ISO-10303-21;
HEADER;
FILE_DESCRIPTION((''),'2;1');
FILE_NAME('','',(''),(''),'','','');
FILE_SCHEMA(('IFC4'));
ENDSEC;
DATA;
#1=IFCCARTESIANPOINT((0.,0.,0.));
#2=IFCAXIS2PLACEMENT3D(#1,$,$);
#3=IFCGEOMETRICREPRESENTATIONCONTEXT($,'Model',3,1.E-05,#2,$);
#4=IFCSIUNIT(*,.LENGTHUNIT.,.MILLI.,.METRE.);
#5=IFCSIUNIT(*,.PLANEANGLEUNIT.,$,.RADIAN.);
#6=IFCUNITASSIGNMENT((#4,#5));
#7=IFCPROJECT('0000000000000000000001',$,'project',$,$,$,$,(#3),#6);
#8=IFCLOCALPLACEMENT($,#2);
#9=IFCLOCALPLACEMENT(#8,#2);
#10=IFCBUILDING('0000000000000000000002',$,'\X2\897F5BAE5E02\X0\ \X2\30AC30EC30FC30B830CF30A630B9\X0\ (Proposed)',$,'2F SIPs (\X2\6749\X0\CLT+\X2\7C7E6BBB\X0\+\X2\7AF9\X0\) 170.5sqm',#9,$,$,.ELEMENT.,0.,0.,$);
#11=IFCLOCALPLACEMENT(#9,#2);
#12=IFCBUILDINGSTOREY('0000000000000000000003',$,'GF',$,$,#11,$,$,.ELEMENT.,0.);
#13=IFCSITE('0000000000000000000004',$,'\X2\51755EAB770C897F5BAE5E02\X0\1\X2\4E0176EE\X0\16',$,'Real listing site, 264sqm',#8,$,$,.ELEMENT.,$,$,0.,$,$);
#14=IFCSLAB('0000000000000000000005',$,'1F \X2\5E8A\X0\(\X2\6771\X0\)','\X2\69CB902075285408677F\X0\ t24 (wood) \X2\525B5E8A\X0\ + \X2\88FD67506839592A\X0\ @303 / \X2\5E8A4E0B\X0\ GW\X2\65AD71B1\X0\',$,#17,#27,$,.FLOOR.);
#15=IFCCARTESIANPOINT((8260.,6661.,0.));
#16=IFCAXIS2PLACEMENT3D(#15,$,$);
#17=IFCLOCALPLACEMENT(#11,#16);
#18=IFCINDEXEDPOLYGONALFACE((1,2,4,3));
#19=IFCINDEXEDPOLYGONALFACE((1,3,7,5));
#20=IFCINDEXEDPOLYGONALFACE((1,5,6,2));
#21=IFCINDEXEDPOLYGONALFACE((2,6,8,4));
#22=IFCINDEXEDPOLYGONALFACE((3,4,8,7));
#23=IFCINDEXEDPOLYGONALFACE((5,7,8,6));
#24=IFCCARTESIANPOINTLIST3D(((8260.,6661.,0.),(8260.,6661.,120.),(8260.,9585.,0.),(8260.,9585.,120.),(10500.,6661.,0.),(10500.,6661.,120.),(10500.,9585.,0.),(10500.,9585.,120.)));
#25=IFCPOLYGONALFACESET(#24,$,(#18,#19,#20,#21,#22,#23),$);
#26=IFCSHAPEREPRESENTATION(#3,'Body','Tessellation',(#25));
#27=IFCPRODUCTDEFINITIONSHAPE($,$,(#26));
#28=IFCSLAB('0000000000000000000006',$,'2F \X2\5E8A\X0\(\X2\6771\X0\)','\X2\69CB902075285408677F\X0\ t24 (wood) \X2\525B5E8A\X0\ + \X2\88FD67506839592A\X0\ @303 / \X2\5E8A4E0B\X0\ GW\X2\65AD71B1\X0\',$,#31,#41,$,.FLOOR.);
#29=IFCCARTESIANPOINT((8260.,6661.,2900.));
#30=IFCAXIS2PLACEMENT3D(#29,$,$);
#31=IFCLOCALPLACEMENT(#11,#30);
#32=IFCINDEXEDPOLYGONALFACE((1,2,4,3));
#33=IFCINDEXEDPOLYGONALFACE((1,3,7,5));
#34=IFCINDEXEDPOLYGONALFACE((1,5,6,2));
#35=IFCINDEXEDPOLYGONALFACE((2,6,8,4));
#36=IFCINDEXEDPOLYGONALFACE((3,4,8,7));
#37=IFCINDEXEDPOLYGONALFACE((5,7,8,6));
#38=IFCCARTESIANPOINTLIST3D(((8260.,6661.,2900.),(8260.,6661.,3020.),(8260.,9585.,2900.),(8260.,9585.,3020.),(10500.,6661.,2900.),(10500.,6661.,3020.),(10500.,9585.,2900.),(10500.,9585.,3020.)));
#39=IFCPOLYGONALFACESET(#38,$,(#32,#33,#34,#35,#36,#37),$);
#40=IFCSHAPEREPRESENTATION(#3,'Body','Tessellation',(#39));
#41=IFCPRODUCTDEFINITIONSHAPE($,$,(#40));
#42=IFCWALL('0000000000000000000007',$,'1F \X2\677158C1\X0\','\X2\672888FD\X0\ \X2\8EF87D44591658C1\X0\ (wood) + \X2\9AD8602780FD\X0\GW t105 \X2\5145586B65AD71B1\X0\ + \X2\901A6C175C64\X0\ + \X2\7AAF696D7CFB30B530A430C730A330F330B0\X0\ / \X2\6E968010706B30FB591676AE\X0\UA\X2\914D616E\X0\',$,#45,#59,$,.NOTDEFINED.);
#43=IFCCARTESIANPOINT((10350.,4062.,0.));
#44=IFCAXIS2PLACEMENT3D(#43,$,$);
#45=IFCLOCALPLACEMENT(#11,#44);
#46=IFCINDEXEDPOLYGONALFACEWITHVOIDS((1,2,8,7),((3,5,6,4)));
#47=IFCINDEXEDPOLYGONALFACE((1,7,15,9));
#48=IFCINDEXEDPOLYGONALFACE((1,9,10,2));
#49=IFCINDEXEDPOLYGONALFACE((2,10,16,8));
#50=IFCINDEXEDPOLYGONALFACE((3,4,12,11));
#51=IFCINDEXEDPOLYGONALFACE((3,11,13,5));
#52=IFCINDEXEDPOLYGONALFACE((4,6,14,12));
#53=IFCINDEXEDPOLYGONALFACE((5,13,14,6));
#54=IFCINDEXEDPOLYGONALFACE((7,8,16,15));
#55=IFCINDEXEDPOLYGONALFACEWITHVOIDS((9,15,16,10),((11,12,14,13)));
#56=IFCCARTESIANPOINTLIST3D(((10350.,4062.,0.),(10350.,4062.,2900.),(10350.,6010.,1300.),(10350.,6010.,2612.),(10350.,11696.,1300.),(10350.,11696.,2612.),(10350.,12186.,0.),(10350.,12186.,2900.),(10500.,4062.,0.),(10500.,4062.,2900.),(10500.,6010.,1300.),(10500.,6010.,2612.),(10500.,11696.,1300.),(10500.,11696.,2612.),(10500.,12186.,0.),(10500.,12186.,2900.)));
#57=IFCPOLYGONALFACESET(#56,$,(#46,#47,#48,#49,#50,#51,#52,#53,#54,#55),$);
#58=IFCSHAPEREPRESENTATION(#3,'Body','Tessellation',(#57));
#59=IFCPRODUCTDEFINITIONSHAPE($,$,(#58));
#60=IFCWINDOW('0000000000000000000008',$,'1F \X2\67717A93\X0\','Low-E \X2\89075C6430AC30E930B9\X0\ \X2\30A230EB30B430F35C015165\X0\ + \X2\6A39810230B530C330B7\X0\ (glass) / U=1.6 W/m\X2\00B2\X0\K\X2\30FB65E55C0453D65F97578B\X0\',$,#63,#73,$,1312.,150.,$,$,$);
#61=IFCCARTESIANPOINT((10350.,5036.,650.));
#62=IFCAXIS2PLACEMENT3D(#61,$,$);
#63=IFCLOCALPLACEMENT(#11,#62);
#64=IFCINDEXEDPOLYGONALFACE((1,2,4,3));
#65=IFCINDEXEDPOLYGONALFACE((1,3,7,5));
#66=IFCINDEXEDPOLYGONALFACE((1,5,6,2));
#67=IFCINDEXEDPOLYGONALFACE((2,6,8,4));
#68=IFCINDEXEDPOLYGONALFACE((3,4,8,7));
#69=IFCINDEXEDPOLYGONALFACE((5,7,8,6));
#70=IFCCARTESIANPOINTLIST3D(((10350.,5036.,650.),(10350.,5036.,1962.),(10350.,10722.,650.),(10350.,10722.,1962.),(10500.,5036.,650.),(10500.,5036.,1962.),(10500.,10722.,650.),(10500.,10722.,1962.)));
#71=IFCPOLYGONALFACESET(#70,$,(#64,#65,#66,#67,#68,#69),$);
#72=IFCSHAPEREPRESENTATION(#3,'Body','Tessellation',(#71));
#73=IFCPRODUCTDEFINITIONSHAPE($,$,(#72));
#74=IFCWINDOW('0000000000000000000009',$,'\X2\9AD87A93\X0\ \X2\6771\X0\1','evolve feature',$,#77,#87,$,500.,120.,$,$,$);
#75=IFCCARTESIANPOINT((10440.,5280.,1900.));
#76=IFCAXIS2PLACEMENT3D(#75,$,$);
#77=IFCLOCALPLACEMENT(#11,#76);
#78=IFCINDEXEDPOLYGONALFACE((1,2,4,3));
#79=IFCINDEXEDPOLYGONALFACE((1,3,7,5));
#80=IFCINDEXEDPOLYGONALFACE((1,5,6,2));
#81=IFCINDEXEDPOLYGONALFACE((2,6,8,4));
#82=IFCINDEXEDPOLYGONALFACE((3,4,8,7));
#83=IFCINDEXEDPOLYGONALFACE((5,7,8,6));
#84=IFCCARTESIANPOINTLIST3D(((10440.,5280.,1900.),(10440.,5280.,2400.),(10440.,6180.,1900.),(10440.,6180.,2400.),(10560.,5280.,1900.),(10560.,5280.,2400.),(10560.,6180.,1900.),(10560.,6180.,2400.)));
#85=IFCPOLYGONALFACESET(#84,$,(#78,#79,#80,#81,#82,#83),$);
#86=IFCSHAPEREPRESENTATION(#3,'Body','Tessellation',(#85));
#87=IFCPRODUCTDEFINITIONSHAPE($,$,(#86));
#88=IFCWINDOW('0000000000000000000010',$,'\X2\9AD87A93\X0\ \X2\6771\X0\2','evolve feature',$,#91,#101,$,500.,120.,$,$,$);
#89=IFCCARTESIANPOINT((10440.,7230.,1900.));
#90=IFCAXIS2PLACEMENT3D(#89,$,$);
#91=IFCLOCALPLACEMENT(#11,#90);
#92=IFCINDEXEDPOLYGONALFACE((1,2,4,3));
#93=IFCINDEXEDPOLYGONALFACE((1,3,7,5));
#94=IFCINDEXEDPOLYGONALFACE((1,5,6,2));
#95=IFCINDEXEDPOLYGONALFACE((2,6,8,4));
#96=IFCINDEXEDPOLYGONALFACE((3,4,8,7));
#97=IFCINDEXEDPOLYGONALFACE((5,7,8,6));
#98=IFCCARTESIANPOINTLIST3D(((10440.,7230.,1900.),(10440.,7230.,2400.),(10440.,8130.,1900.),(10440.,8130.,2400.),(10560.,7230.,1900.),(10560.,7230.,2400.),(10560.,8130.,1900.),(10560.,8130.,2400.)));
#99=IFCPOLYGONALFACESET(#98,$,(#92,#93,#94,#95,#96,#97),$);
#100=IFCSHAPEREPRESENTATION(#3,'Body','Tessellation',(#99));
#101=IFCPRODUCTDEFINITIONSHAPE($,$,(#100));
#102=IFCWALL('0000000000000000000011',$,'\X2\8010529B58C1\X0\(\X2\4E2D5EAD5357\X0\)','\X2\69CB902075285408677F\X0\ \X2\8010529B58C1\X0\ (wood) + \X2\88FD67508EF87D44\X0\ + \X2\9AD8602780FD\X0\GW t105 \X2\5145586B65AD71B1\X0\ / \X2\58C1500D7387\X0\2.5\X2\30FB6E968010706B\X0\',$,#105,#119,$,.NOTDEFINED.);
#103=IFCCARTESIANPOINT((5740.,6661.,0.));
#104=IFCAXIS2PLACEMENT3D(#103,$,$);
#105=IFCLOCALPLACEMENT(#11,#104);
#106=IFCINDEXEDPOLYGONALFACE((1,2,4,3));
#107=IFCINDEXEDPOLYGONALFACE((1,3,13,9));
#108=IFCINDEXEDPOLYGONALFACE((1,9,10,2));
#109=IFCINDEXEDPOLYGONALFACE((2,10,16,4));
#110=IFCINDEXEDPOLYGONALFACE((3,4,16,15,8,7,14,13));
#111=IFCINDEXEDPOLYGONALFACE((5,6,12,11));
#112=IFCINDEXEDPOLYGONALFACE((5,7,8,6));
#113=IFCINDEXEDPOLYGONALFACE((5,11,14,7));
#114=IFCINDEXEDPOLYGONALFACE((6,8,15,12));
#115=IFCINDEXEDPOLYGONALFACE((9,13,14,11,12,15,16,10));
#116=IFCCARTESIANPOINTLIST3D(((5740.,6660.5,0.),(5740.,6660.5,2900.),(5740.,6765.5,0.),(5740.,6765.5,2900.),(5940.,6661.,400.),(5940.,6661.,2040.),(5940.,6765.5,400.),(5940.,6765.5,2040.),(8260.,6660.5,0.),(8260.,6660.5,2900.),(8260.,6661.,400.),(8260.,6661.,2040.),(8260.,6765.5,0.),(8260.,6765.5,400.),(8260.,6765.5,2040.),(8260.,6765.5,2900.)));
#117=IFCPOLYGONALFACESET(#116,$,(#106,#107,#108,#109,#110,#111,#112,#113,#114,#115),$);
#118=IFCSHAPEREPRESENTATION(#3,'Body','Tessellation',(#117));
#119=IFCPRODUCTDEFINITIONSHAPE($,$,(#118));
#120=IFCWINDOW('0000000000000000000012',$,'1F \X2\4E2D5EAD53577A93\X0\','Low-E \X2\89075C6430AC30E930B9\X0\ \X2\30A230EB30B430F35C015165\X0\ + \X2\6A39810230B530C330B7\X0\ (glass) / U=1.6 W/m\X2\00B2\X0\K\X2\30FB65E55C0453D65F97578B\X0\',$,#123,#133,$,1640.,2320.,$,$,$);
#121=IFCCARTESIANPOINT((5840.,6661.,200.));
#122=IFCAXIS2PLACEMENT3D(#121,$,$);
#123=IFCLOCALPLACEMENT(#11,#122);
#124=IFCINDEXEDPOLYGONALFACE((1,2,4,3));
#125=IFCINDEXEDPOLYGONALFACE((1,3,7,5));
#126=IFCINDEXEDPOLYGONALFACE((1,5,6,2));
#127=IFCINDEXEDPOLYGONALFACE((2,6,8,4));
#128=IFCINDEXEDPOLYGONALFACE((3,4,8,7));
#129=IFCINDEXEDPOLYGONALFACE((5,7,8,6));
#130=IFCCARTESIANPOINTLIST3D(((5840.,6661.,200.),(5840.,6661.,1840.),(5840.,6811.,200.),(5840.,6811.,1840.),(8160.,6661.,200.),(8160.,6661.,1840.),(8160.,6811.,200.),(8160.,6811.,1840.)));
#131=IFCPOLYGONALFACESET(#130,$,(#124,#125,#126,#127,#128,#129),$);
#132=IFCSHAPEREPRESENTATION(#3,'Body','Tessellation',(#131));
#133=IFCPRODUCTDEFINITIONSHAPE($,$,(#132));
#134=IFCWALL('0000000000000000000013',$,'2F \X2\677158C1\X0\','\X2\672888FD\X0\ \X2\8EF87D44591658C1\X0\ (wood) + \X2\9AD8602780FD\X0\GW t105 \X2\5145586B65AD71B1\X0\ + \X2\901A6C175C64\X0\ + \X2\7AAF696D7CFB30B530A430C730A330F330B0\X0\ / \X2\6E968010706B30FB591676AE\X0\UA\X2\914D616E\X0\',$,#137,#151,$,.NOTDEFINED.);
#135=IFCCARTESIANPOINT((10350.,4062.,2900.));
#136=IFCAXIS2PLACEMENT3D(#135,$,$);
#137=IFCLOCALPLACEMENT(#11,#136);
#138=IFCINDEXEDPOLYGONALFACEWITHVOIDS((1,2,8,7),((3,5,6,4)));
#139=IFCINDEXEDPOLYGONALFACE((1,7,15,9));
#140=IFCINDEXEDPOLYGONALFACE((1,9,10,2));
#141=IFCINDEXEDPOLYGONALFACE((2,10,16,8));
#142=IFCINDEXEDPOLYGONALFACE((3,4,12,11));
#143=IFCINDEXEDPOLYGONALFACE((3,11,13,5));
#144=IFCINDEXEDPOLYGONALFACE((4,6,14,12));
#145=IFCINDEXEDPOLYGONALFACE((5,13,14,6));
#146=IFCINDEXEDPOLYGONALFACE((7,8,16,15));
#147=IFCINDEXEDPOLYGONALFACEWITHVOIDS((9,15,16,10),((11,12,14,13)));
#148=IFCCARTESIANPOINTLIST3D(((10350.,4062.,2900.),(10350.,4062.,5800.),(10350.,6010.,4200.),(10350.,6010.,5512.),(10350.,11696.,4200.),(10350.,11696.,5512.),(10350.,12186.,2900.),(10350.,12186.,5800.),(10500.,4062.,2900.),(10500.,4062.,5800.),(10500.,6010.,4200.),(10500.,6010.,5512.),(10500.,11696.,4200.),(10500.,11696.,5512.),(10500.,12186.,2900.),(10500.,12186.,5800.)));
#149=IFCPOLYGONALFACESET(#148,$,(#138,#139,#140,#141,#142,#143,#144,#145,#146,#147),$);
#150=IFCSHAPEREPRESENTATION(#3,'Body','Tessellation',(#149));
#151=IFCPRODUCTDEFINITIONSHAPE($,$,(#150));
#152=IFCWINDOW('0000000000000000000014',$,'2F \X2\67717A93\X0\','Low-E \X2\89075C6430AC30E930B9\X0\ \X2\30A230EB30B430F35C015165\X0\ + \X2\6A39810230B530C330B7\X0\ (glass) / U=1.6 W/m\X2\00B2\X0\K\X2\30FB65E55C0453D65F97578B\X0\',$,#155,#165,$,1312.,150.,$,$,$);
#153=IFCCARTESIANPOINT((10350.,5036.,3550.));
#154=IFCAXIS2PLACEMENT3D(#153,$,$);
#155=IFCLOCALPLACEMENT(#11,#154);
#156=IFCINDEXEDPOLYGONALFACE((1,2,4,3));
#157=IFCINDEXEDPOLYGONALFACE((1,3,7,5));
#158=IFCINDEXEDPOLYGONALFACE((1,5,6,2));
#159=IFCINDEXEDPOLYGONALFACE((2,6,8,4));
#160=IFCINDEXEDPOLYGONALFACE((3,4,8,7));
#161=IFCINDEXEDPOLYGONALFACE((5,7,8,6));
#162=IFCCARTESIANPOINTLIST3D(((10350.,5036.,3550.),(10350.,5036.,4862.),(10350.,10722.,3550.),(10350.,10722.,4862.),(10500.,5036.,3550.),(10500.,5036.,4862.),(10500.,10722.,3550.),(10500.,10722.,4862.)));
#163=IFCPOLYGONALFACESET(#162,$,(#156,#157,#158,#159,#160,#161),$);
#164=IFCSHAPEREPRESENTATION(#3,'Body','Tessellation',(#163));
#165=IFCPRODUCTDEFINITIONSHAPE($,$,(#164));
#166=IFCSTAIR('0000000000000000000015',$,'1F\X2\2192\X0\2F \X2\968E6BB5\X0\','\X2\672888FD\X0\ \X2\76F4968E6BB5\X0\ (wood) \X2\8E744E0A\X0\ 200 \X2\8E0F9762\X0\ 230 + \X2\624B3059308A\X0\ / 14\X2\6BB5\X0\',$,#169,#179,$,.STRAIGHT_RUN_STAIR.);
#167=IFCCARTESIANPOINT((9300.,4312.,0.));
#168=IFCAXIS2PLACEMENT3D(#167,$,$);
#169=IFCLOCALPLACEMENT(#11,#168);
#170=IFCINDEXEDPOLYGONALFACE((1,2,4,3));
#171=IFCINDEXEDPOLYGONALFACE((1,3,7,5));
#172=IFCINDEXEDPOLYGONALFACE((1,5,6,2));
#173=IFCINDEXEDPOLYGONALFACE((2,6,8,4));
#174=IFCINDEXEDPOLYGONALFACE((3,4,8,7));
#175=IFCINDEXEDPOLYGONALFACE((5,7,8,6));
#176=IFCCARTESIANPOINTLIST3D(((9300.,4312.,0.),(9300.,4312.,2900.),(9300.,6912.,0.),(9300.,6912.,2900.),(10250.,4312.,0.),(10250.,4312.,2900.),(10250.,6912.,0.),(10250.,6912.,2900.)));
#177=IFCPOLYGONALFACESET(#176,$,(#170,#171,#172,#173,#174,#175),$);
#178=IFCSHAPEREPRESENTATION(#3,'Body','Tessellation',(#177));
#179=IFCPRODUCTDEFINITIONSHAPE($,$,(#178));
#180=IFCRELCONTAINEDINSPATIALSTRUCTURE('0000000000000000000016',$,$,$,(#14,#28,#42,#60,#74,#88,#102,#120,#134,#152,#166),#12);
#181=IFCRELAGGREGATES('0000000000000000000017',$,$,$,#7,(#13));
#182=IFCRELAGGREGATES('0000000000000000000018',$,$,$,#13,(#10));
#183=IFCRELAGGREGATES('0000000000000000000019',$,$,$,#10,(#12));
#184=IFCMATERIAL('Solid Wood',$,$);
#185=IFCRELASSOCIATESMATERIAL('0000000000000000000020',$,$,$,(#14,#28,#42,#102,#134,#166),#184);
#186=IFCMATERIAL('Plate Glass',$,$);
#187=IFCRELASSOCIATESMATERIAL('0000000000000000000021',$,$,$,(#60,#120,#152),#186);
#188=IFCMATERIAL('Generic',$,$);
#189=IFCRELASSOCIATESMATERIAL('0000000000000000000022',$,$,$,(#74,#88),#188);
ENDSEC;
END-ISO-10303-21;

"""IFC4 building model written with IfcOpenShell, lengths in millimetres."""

from ifc_helpers import new_model, si_unit, frame, frame_2d, origin, place, context, project, spatial, rectangle, extrude, material, element, fill, save


model = new_model("IFC4")

# Units and contexts
model_context = context("Model", 3, precision=1e-05, world=origin())
ifc_project = project(units=[si_unit("LENGTHUNIT", "METRE", prefix="MILLI"), si_unit("PLANEANGLEUNIT", "RADIAN")], contexts=[model_context])

# Site, building, storey
site_placement = place(None, origin())
site = spatial("IfcSite", under=ifc_project, at=site_placement, Name="兵庫県西宮市1丁目16", ObjectType="Real listing site, 264sqm", CompositionType="ELEMENT", RefElevation=0.0)
building_placement = place(site_placement, origin())
building = spatial("IfcBuilding", under=site, at=building_placement, Name="西宮市 ガレージハウス (Proposed)", ObjectType="2F SIPs (杉CLT+籾殻+竹) 170.5sqm", CompositionType="ELEMENT", ElevationOfRefHeight=0.0, ElevationOfTerrain=0.0)
storey_placement = place(building_placement, origin())
storey = spatial("IfcBuildingStorey", under=building, at=storey_placement, Name="GF", CompositionType="ELEMENT", Elevation=0.0)

# Slabs
ifc_material_1 = material(Name="Solid Wood")
slab_1_placement = place(storey_placement, frame((8260.0, 6661.0, 0.0)))
element("IfcSlab", 1, at=slab_1_placement, inside=storey, material=ifc_material_1, Name="1F 床(東)", Description="構造用合板 t24 (wood) 剛床 + 製材根太 @303 / 床下 GW断熱", PredefinedType="FLOOR", context=model_context, shape_type="SweptSolid", body=[
    extrude(rectangle(XDim=2240.0, YDim=2924.0, at=frame_2d((1120.0, 1462.0))), frame((8260.0, 6661.0, 0.0)), (0.0, 0.0, 1.0), 120.0),
])
slab_2_placement = place(storey_placement, frame((8260.0, 6661.0, 2900.0)))
element("IfcSlab", 2, at=slab_2_placement, inside=storey, material=ifc_material_1, Name="2F 床(東)", Description="構造用合板 t24 (wood) 剛床 + 製材根太 @303 / 床下 GW断熱", PredefinedType="FLOOR", context=model_context, shape_type="SweptSolid", body=[
    extrude(rectangle(XDim=2240.0, YDim=2924.0, at=frame_2d((1120.0, 1462.0))), frame((8260.0, 6661.0, 2900.0)), (0.0, 0.0, 1.0), 120.0),
])

# Wall, openings, windows
wall_1_placement = place(storey_placement, frame((10350.0, 4062.0, 0.0)))
wall_1 = element("IfcWall", 3, at=wall_1_placement, inside=storey, material=ifc_material_1, Name="1F 東壁", Description="木製 軸組外壁 (wood) + 高性能GW t105 充填断熱 + 通気層 + 窯業系サイディング / 準耐火・外皮UA配慮", PredefinedType="NOTDEFINED", context=model_context, shape_type="SweptSolid", body=[
    extrude(rectangle(XDim=150.0, YDim=8124.0, at=frame_2d((75.0, 4062.0))), frame((10350.0, 4062.0, 0.0)), (0.0, 0.0, 1.0), 2900.0),
])
opening_1_placement = place(storey_placement, frame((10350.0, 5036.0, 650.0)))
opening_1 = element("IfcOpeningElement", 4, at=opening_1_placement, cuts=wall_1, PredefinedType="NOTDEFINED", context=model_context, shape_type="SweptSolid", body=[
    extrude(rectangle(XDim=150.0, YDim=5686.0, at=frame_2d((75.0, 2843.0))), frame((10350.0, 5036.0, 650.0)), (0.0, 0.0, 1.0), 1312.0),
])
opening_2_placement = place(storey_placement, frame((10440.0, 5280.0, 1900.0)))
opening_2 = element("IfcOpeningElement", 5, at=opening_2_placement, cuts=wall_1, PredefinedType="NOTDEFINED", context=model_context, shape_type="SweptSolid", body=[
    extrude(rectangle(XDim=120.0, YDim=900.0, at=frame_2d((60.0, 450.0))), frame((10440.0, 5280.0, 1900.0)), (0.0, 0.0, 1.0), 500.0),
])
opening_3_placement = place(storey_placement, frame((10440.0, 7230.0, 1900.0)))
opening_3 = element("IfcOpeningElement", 6, at=opening_3_placement, cuts=wall_1, PredefinedType="NOTDEFINED", context=model_context, shape_type="SweptSolid", body=[
    extrude(rectangle(XDim=120.0, YDim=900.0, at=frame_2d((60.0, 450.0))), frame((10440.0, 7230.0, 1900.0)), (0.0, 0.0, 1.0), 500.0),
])
ifc_material_2 = material(Name="Plate Glass")
window_1_placement = place(storey_placement, frame((10350.0, 5036.0, 650.0)))
window_1 = element("IfcWindow", 7, at=window_1_placement, inside=storey, material=ifc_material_2, Name="1F 東窓", Description="Low-E 複層ガラス アルゴン封入 + 樹脂サッシ (glass) / U=1.6 W/m²K・日射取得型", OverallHeight=1312.0, OverallWidth=150.0, context=model_context, shape_type="SweptSolid", body=[
    extrude(rectangle(XDim=150.0, YDim=5686.0, at=frame_2d((75.0, 2843.0))), frame((10350.0, 5036.0, 650.0)), (0.0, 0.0, 1.0), 1312.0),
])
fill(opening_1, window_1)
ifc_material_3 = material(Name="Generic")
window_2_placement = place(storey_placement, frame((10440.0, 5280.0, 1900.0)))
window_2 = element("IfcWindow", 8, at=window_2_placement, inside=storey, material=ifc_material_3, Name="高窓 東1", Description="evolve feature", OverallHeight=500.0, OverallWidth=120.0, context=model_context, shape_type="SweptSolid", body=[
    extrude(rectangle(XDim=120.0, YDim=900.0, at=frame_2d((60.0, 450.0))), frame((10440.0, 5280.0, 1900.0)), (0.0, 0.0, 1.0), 500.0),
])
fill(opening_2, window_2)
window_3_placement = place(storey_placement, frame((10440.0, 7230.0, 1900.0)))
window_3 = element("IfcWindow", 9, at=window_3_placement, inside=storey, material=ifc_material_3, Name="高窓 東2", Description="evolve feature", OverallHeight=500.0, OverallWidth=120.0, context=model_context, shape_type="SweptSolid", body=[
    extrude(rectangle(XDim=120.0, YDim=900.0, at=frame_2d((60.0, 450.0))), frame((10440.0, 7230.0, 1900.0)), (0.0, 0.0, 1.0), 500.0),
])
fill(opening_3, window_3)

# Wall, opening, window
wall_2_placement = place(storey_placement, frame((5740.0, 6661.0, 0.0)))
wall_2 = element("IfcWall", 10, at=wall_2_placement, inside=storey, material=ifc_material_1, Name="耐力壁(中庭南)", Description="構造用合板 耐力壁 (wood) + 製材軸組 + 高性能GW t105 充填断熱 / 壁倍率2.5・準耐火", PredefinedType="NOTDEFINED", context=model_context, shape_type="SweptSolid", body=[
    extrude(rectangle(XDim=2520.0, YDim=105.0, at=frame_2d((1260.0, 52.0))), frame((5740.0, 6661.0, 0.0)), (0.0, 0.0, 1.0), 2900.0),
])
opening_4_placement = place(storey_placement, frame((5840.0, 6661.0, 200.0)))
opening_4 = element("IfcOpeningElement", 11, at=opening_4_placement, cuts=wall_2, PredefinedType="NOTDEFINED", context=model_context, shape_type="SweptSolid", body=[
    extrude(rectangle(XDim=2320.0, YDim=150.0, at=frame_2d((1160.0, 75.0))), frame((5840.0, 6661.0, 200.0)), (0.0, 0.0, 1.0), 1640.0),
])
window_4_placement = place(storey_placement, frame((5840.0, 6661.0, 200.0)))
window_4 = element("IfcWindow", 12, at=window_4_placement, inside=storey, material=ifc_material_2, Name="1F 中庭南窓", Description="Low-E 複層ガラス アルゴン封入 + 樹脂サッシ (glass) / U=1.6 W/m²K・日射取得型", OverallHeight=1640.0, OverallWidth=2320.0, context=model_context, shape_type="SweptSolid", body=[
    extrude(rectangle(XDim=2320.0, YDim=150.0, at=frame_2d((1160.0, 75.0))), frame((5840.0, 6661.0, 200.0)), (0.0, 0.0, 1.0), 1640.0),
])
fill(opening_4, window_4)

# Wall, opening, window
wall_3_placement = place(storey_placement, frame((10350.0, 4062.0, 2900.0)))
wall_3 = element("IfcWall", 13, at=wall_3_placement, inside=storey, material=ifc_material_1, Name="2F 東壁", Description="木製 軸組外壁 (wood) + 高性能GW t105 充填断熱 + 通気層 + 窯業系サイディング / 準耐火・外皮UA配慮", PredefinedType="NOTDEFINED", context=model_context, shape_type="SweptSolid", body=[
    extrude(rectangle(XDim=150.0, YDim=8124.0, at=frame_2d((75.0, 4062.0))), frame((10350.0, 4062.0, 2900.0)), (0.0, 0.0, 1.0), 2900.0),
])
opening_5_placement = place(storey_placement, frame((10350.0, 5036.0, 3550.0)))
opening_5 = element("IfcOpeningElement", 14, at=opening_5_placement, cuts=wall_3, PredefinedType="NOTDEFINED", context=model_context, shape_type="SweptSolid", body=[
    extrude(rectangle(XDim=150.0, YDim=5686.0, at=frame_2d((75.0, 2843.0))), frame((10350.0, 5036.0, 3550.0)), (0.0, 0.0, 1.0), 1312.0),
])
window_5_placement = place(storey_placement, frame((10350.0, 5036.0, 3550.0)))
window_5 = element("IfcWindow", 15, at=window_5_placement, inside=storey, material=ifc_material_2, Name="2F 東窓", Description="Low-E 複層ガラス アルゴン封入 + 樹脂サッシ (glass) / U=1.6 W/m²K・日射取得型", OverallHeight=1312.0, OverallWidth=150.0, context=model_context, shape_type="SweptSolid", body=[
    extrude(rectangle(XDim=150.0, YDim=5686.0, at=frame_2d((75.0, 2843.0))), frame((10350.0, 5036.0, 3550.0)), (0.0, 0.0, 1.0), 1312.0),
])
fill(opening_5, window_5)

# Stair
stair_placement = place(storey_placement, frame((9300.0, 4312.0, 0.0)))
element("IfcStair", 16, at=stair_placement, inside=storey, material=ifc_material_1, Name="1F→2F 階段", Description="木製 直階段 (wood) 蹴上 200 踏面 230 + 手すり / 14段", PredefinedType="STRAIGHT_RUN_STAIR", context=model_context, shape_type="SweptSolid", body=[
    extrude(rectangle(XDim=950.0, YDim=2600.0, at=frame_2d((475.0, 1300.0))), frame((9300.0, 4312.0, 0.0)), (0.0, 0.0, 1.0), 2900.0),
])

save(model, "model.ifc")
